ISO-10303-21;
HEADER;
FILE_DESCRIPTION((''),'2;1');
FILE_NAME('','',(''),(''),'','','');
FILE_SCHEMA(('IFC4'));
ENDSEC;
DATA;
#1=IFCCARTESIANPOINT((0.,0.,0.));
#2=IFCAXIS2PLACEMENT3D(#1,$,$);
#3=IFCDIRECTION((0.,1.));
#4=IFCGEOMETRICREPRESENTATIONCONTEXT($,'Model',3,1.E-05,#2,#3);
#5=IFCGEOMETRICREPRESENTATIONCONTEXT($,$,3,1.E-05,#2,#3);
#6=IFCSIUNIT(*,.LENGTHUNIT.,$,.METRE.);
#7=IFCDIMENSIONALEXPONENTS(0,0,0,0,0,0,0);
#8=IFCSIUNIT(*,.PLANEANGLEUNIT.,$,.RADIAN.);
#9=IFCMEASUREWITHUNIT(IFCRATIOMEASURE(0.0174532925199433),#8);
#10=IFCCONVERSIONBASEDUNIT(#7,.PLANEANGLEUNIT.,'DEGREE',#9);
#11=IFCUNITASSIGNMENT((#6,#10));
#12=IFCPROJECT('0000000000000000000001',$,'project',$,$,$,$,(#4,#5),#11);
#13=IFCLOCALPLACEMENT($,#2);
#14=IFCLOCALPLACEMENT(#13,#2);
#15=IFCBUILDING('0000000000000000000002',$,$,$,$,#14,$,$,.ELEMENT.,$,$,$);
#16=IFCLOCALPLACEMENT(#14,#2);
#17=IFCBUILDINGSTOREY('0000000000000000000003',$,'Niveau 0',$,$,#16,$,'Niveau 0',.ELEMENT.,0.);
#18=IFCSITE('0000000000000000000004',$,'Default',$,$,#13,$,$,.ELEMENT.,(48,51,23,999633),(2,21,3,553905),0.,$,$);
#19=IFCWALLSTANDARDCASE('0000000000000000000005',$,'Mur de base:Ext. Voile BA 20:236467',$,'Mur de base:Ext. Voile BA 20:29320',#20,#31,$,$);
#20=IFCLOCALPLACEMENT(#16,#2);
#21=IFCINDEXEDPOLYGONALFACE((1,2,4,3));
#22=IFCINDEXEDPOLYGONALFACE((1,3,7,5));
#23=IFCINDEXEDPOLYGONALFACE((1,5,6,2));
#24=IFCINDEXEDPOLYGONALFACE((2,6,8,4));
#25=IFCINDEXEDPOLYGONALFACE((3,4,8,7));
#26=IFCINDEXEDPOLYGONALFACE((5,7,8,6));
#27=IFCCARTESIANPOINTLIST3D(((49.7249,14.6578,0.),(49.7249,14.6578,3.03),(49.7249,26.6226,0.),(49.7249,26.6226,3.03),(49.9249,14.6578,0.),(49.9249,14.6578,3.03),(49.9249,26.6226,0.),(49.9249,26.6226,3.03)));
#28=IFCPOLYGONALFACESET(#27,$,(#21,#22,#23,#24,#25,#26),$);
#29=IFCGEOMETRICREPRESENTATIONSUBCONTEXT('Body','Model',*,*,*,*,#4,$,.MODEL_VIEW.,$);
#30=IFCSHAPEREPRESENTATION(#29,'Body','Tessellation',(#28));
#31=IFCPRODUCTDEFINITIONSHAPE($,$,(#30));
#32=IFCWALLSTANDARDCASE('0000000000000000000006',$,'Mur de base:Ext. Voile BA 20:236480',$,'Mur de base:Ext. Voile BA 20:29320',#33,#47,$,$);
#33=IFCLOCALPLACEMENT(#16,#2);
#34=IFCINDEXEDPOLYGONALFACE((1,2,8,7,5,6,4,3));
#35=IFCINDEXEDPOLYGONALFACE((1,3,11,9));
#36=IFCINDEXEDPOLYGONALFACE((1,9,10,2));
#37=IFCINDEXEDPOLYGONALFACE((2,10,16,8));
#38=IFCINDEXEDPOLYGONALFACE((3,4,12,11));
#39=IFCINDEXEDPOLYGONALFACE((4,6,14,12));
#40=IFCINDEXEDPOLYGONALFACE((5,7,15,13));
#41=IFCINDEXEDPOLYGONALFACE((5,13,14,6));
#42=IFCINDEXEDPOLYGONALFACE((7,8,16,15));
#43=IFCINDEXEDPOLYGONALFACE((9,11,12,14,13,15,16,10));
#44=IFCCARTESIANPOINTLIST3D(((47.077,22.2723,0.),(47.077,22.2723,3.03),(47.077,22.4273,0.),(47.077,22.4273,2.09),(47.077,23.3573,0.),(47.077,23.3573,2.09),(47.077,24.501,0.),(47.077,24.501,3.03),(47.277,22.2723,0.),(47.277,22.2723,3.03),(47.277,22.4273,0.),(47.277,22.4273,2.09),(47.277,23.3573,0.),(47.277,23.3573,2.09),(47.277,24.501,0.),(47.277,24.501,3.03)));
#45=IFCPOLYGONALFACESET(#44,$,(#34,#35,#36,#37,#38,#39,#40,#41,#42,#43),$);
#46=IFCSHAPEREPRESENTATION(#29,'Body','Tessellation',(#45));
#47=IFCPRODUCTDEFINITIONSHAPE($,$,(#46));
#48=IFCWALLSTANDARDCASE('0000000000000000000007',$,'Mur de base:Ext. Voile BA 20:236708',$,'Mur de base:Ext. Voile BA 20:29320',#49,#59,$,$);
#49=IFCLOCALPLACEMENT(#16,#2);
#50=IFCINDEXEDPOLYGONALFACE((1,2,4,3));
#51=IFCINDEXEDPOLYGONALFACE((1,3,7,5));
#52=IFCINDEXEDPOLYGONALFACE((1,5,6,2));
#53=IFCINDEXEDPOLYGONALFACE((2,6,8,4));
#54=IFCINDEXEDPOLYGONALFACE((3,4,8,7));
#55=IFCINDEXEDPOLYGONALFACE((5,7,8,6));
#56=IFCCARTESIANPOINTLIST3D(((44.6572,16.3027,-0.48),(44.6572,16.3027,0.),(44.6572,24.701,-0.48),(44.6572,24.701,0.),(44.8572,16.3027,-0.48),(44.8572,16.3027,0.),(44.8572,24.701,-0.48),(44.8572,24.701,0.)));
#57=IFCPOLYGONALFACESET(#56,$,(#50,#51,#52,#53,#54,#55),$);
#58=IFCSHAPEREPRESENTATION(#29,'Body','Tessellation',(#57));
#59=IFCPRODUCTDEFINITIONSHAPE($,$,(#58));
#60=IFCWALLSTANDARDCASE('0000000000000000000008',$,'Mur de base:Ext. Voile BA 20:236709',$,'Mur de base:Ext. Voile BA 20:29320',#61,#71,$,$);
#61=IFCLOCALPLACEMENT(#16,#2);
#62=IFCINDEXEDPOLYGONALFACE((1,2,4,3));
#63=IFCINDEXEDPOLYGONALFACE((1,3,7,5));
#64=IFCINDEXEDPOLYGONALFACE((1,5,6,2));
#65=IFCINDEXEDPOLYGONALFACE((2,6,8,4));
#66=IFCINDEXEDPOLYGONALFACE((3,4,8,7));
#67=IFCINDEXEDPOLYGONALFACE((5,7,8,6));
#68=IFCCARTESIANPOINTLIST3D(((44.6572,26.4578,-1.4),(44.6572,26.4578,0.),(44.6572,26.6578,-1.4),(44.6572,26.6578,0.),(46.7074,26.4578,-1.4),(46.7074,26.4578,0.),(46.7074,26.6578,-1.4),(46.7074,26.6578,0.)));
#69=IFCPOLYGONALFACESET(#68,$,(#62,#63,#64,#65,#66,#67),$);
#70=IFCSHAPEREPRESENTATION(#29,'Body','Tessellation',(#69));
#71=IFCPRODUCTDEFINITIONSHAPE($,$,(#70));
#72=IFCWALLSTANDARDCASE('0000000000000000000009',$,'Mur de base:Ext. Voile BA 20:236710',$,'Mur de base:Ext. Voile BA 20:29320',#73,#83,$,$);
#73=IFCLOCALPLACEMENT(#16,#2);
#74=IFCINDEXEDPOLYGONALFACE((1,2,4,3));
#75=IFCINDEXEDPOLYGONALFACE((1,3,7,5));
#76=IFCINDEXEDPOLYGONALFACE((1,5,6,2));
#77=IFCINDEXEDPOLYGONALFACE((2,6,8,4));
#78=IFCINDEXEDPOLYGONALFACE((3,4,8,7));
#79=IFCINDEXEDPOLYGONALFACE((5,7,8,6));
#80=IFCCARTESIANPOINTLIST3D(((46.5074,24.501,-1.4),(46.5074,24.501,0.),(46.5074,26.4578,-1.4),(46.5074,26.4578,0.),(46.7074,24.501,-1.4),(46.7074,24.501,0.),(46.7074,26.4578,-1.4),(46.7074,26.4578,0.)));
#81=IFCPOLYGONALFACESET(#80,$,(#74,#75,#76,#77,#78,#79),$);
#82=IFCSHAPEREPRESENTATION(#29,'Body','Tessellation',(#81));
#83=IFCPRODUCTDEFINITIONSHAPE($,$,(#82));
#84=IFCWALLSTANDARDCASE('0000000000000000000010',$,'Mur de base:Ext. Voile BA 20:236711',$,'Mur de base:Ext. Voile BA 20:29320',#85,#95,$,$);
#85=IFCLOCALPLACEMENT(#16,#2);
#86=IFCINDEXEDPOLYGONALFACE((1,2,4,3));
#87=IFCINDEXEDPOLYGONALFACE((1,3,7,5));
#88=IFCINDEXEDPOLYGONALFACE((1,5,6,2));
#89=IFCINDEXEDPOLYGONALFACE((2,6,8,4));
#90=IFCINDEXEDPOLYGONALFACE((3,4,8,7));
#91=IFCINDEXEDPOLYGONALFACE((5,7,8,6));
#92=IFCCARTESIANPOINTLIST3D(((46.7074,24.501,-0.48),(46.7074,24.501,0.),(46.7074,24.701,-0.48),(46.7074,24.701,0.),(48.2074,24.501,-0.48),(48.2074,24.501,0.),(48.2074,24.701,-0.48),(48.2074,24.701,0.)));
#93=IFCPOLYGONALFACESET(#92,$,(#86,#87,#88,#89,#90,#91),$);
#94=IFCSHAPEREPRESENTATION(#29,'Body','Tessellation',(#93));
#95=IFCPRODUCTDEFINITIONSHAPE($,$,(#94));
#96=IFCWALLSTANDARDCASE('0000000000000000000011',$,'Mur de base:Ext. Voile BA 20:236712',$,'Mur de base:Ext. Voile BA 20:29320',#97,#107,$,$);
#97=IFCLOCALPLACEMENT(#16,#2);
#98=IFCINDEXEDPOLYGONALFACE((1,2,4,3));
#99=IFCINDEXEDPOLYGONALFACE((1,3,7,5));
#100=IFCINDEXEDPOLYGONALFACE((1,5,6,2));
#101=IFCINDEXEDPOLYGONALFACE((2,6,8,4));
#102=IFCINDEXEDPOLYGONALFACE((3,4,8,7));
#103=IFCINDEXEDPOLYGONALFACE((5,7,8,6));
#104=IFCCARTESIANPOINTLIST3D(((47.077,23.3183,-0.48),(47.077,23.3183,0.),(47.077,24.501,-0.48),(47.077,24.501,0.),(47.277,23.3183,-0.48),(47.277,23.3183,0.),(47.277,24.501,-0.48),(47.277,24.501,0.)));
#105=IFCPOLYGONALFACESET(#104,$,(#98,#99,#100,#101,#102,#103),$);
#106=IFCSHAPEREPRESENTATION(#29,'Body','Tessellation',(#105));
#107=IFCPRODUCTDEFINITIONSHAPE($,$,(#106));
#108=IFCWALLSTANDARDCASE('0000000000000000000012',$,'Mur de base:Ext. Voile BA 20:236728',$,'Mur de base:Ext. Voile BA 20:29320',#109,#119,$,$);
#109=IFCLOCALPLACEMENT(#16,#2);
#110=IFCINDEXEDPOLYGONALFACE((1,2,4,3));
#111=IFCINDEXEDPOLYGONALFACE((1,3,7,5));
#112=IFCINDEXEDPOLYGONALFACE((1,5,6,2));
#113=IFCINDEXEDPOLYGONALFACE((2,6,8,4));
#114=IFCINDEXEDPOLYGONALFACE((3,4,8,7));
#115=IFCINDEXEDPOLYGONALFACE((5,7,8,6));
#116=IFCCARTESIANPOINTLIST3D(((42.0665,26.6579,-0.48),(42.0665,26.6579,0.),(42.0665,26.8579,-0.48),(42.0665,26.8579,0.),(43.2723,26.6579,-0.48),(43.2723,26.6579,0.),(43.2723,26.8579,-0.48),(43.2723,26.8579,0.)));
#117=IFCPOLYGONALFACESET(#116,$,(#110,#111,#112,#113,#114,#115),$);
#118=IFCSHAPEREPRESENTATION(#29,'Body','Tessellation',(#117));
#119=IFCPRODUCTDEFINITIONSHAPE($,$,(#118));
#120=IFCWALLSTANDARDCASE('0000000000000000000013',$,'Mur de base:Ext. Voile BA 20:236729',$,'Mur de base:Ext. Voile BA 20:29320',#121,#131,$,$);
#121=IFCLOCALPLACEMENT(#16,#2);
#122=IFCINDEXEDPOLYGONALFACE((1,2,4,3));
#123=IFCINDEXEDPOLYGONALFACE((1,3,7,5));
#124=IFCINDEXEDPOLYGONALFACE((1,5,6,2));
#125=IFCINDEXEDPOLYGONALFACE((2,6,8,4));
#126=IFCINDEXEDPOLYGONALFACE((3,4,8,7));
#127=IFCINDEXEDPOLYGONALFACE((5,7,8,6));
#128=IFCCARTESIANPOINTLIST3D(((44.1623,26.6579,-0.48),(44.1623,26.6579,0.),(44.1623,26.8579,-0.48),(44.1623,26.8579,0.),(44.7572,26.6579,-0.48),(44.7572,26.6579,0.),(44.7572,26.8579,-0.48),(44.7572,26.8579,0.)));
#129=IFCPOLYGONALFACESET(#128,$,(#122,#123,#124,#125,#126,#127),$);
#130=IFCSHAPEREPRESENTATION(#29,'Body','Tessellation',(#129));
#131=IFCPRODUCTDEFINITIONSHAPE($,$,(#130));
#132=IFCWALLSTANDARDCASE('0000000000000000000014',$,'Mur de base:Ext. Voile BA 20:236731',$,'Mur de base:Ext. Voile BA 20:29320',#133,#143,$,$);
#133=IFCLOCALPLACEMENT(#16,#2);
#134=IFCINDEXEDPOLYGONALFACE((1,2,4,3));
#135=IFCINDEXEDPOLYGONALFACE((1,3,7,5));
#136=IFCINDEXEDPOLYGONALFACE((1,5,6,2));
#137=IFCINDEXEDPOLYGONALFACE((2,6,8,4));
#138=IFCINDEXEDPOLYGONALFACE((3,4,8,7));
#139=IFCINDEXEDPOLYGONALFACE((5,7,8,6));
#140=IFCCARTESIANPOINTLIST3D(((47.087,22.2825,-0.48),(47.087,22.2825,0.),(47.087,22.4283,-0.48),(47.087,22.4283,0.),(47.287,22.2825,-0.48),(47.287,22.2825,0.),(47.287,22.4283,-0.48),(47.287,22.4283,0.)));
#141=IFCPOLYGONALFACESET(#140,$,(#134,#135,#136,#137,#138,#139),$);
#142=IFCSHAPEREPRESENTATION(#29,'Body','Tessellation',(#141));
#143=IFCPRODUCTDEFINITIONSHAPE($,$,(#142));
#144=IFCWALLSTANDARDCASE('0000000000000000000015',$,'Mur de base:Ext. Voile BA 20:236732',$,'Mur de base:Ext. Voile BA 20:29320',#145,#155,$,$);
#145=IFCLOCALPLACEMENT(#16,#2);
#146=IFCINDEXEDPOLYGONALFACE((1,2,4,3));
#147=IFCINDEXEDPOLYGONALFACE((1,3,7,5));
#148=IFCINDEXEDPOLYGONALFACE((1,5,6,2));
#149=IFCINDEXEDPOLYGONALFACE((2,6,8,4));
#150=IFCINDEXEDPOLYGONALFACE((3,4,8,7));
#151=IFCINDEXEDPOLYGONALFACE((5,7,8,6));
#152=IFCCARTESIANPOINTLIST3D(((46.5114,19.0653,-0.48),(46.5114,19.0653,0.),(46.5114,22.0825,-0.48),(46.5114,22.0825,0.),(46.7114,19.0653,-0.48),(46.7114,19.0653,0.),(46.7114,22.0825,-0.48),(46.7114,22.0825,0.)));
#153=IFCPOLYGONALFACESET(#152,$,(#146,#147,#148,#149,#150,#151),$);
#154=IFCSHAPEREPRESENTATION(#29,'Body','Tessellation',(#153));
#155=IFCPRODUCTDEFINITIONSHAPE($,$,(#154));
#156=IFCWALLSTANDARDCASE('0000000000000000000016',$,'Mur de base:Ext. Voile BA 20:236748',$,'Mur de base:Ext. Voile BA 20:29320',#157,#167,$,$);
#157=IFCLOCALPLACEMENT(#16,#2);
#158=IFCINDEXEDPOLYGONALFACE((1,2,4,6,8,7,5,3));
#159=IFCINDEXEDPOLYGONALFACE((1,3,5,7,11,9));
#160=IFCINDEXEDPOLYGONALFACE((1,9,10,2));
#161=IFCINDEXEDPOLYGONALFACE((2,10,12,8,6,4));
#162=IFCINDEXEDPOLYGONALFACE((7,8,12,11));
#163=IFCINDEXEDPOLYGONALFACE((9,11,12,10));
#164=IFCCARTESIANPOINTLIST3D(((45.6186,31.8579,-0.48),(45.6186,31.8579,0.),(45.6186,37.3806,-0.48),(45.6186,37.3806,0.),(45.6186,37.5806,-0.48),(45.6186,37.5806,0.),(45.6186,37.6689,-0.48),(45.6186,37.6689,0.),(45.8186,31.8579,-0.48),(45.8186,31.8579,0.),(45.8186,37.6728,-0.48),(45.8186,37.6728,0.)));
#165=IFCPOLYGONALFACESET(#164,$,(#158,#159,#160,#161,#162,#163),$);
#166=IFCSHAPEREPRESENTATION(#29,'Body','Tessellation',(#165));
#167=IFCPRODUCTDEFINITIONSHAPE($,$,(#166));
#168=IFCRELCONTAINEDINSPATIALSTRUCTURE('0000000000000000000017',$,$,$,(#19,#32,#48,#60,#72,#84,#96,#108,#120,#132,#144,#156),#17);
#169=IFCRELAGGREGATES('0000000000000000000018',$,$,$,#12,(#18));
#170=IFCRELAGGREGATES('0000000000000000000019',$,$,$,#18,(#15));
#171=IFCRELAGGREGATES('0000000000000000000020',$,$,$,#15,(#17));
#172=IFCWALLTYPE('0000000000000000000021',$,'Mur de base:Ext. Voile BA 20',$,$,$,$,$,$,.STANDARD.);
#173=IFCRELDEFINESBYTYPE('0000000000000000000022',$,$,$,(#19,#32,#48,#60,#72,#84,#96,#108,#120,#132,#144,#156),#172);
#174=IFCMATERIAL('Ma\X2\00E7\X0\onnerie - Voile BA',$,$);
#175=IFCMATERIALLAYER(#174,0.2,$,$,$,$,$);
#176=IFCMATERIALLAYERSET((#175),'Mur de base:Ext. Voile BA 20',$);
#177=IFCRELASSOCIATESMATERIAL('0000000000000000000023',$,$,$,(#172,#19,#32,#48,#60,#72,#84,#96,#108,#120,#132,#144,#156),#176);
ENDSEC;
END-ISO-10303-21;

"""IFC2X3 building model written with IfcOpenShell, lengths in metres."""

from ifc_helpers import new_model, entity, si_unit, converted_unit, direction, frame, frame_2d, origin, origin_2d_with_axis, place, context, subcontext, project, spatial, polyline, rectangle, outline, extrude, material, layer, layer_set, layer_usage, type_object, element, save


model = new_model("IFC2X3")

# Units and contexts
model_context = context("Model", 3, precision=1e-05, world=origin(), true_north=direction((0.0, 1.0)))
context_of_model = context(None, 3, precision=1e-05, world=origin(), true_north=direction((0.0, 1.0)))
body_context = subcontext(model_context, "Body", "Model", "MODEL_VIEW")
ifc_project = project(units=[si_unit("LENGTHUNIT", "METRE"), converted_unit("PLANEANGLEUNIT", "DEGREE", entity("IfcRatioMeasure", 0.0174532925199433), si_unit("PLANEANGLEUNIT", "RADIAN"), dimensions=[0, 0, 0, 0, 0, 0, 0])], contexts=[model_context, context_of_model])

# Site, building, storey
site_placement = place(None, origin())
site = spatial("IfcSite", under=ifc_project, at=site_placement, Name="Default", CompositionType="ELEMENT", RefLatitude=(48, 51, 23, 999633), RefLongitude=(2, 21, 3, 553905), RefElevation=0.0)
building_placement = place(site_placement, origin())
building = spatial("IfcBuilding", under=site, at=building_placement, CompositionType="ELEMENT")
storey_placement = place(building_placement, origin())
storey = spatial("IfcBuildingStorey", under=building, at=storey_placement, Name="Niveau 0", LongName="Niveau 0", CompositionType="ELEMENT", Elevation=0.0)

# Shared definitions
ifc_material = material(Name="Maçonnerie - Voile BA")
ifc_layer_1 = layer(ifc_material, 0.2)
ifc_layer_set_1 = layer_set([ifc_layer_1], Name="Mur de base:Ext. Voile BA 20")
wall_type_1 = type_object("IfcWallType", Name="Mur de base:Ext. Voile BA 20", PredefinedType="STANDARD", material=ifc_layer_set_1)

# Wall
ifc_layer_usage_1 = layer_usage(ifc_layer_set_1, "AXIS2", "NEGATIVE", 0.1)
wall_1_placement = place(storey_placement, frame((49.8249, 26.6226, 0.0), z_axis=(0.0, 0.0, 1.0), x_axis=(0.0, -1.0, 0.0)))
element("IfcWallStandardCase", 1, at=wall_1_placement, inside=storey, type_object=wall_type_1, material=ifc_layer_usage_1, Name="Mur de base:Ext. Voile BA 20:236467", ObjectType="Mur de base:Ext. Voile BA 20:29320", context=body_context, shape_type="SweptSolid", body=[
    extrude(rectangle(XDim=11.9648, YDim=0.2, at=frame_2d((5.9824, 0.0), x_axis=(-1.0, 0.0))), origin(), (0.0, 0.0, 1.0), 3.03),
])

# Wall, opening
ifc_layer_usage_2 = layer_usage(ifc_layer_set_1, "AXIS2", "NEGATIVE", 0.1)
wall_2_placement = place(storey_placement, frame((47.177, 24.501, 0.0), z_axis=(0.0, 0.0, 1.0), x_axis=(0.0, -1.0, 0.0)))
wall_2 = element("IfcWallStandardCase", 2, at=wall_2_placement, inside=storey, type_object=wall_type_1, material=ifc_layer_usage_2, Name="Mur de base:Ext. Voile BA 20:236480", ObjectType="Mur de base:Ext. Voile BA 20:29320", context=body_context, shape_type="SweptSolid", body=[
    extrude(rectangle(XDim=2.2287, YDim=0.2, at=frame_2d((1.1144, 0.0), x_axis=(-1.0, 0.0))), origin(), (0.0, 0.0, 1.0), 3.03),
])
opening_1_placement = place(wall_2_placement, origin())
element("IfcOpeningElement", 3, at=opening_1_placement, cuts=wall_2, ObjectType="Opening", context=body_context, shape_type="SweptSolid", body=[
    extrude(rectangle(XDim=2.09, YDim=0.93, at=origin_2d_with_axis()), frame((1.6087, -0.1, 1.045), z_axis=(0.0, 1.0, 0.0), x_axis=(0.0, 0.0, -1.0)), (0.0, 0.0, 1.0), 0.2),
])

# Walls
ifc_layer_usage_3 = layer_usage(ifc_layer_set_1, "AXIS2", "NEGATIVE", 0.1)
wall_3_placement = place(storey_placement, frame((44.7572, 24.701, -0.48), z_axis=(0.0, 0.0, 1.0), x_axis=(0.0, -1.0, 0.0)))
element("IfcWallStandardCase", 4, at=wall_3_placement, inside=storey, type_object=wall_type_1, material=ifc_layer_usage_3, Name="Mur de base:Ext. Voile BA 20:236708", ObjectType="Mur de base:Ext. Voile BA 20:29320", context=body_context, shape_type="SweptSolid", body=[
    extrude(rectangle(XDim=8.3983, YDim=0.2, at=frame_2d((4.1992, 0.0), x_axis=(-1.0, 0.0))), origin(), (0.0, 0.0, 1.0), 0.48),
])
ifc_layer_usage_4 = layer_usage(ifc_layer_set_1, "AXIS2", "NEGATIVE", 0.1)
wall_4_placement = place(storey_placement, frame((44.6572, 26.5578, -1.4)))
element("IfcWallStandardCase", 5, at=wall_4_placement, inside=storey, type_object=wall_type_1, material=ifc_layer_usage_4, Name="Mur de base:Ext. Voile BA 20:236709", ObjectType="Mur de base:Ext. Voile BA 20:29320", context=body_context, shape_type="SweptSolid", body=[
    extrude(rectangle(XDim=2.0501, YDim=0.2, at=frame_2d((1.0251, 0.0), x_axis=(-1.0, 0.0))), origin(), (0.0, 0.0, 1.0), 1.4),
])
ifc_layer_usage_5 = layer_usage(ifc_layer_set_1, "AXIS2", "NEGATIVE", 0.1)
wall_5_placement = place(storey_placement, frame((46.6074, 26.4578, -1.4), z_axis=(0.0, 0.0, 1.0), x_axis=(0.0, -1.0, 0.0)))
element("IfcWallStandardCase", 6, at=wall_5_placement, inside=storey, type_object=wall_type_1, material=ifc_layer_usage_5, Name="Mur de base:Ext. Voile BA 20:236710", ObjectType="Mur de base:Ext. Voile BA 20:29320", context=body_context, shape_type="SweptSolid", body=[
    extrude(rectangle(XDim=1.9568, YDim=0.2, at=frame_2d((0.9784, 0.0), x_axis=(-1.0, 0.0))), origin(), (0.0, 0.0, 1.0), 1.4),
])
ifc_layer_usage_6 = layer_usage(ifc_layer_set_1, "AXIS2", "NEGATIVE", 0.1)
wall_6_placement = place(storey_placement, frame((46.7074, 24.601, -0.48)))
element("IfcWallStandardCase", 7, at=wall_6_placement, inside=storey, type_object=wall_type_1, material=ifc_layer_usage_6, Name="Mur de base:Ext. Voile BA 20:236711", ObjectType="Mur de base:Ext. Voile BA 20:29320", context=body_context, shape_type="SweptSolid", body=[
    extrude(rectangle(XDim=1.5, YDim=0.2, at=frame_2d((0.75, 0.0), x_axis=(-1.0, 0.0))), origin(), (0.0, 0.0, 1.0), 0.48),
])
ifc_layer_usage_7 = layer_usage(ifc_layer_set_1, "AXIS2", "NEGATIVE", 0.1)
wall_7_placement = place(storey_placement, frame((47.177, 23.3183, -0.48), z_axis=(0.0, 0.0, 1.0), x_axis=(0.0, 1.0, 0.0)))
element("IfcWallStandardCase", 8, at=wall_7_placement, inside=storey, type_object=wall_type_1, material=ifc_layer_usage_7, Name="Mur de base:Ext. Voile BA 20:236712", ObjectType="Mur de base:Ext. Voile BA 20:29320", context=body_context, shape_type="SweptSolid", body=[
    extrude(rectangle(XDim=1.1827, YDim=0.2, at=frame_2d((0.5914, 0.0), x_axis=(-1.0, 0.0))), origin(), (0.0, 0.0, 1.0), 0.48),
])
ifc_layer_usage_8 = layer_usage(ifc_layer_set_1, "AXIS2", "NEGATIVE", 0.1)
wall_8_placement = place(storey_placement, frame((42.0665, 26.7579, -0.48)))
element("IfcWallStandardCase", 9, at=wall_8_placement, inside=storey, type_object=wall_type_1, material=ifc_layer_usage_8, Name="Mur de base:Ext. Voile BA 20:236728", ObjectType="Mur de base:Ext. Voile BA 20:29320", context=body_context, shape_type="SweptSolid", body=[
    extrude(rectangle(XDim=1.2058, YDim=0.2, at=frame_2d((0.6029, 0.0), x_axis=(-1.0, 0.0))), origin(), (0.0, 0.0, 1.0), 0.48),
])
ifc_layer_usage_9 = layer_usage(ifc_layer_set_1, "AXIS2", "NEGATIVE", 0.1)
wall_9_placement = place(storey_placement, frame((44.1623, 26.7579, -0.48)))
element("IfcWallStandardCase", 10, at=wall_9_placement, inside=storey, type_object=wall_type_1, material=ifc_layer_usage_9, Name="Mur de base:Ext. Voile BA 20:236729", ObjectType="Mur de base:Ext. Voile BA 20:29320", context=body_context, shape_type="SweptSolid", body=[
    extrude(rectangle(XDim=0.595, YDim=0.2, at=frame_2d((0.2975, 0.0), x_axis=(-1.0, 0.0))), origin(), (0.0, 0.0, 1.0), 0.48),
])
ifc_layer_usage_10 = layer_usage(ifc_layer_set_1, "AXIS2", "NEGATIVE", 0.1)
wall_10_placement = place(storey_placement, frame((47.187, 22.2825, -0.48), z_axis=(0.0, 0.0, 1.0), x_axis=(0.0, 1.0, 0.0)))
element("IfcWallStandardCase", 11, at=wall_10_placement, inside=storey, type_object=wall_type_1, material=ifc_layer_usage_10, Name="Mur de base:Ext. Voile BA 20:236731", ObjectType="Mur de base:Ext. Voile BA 20:29320", context=body_context, shape_type="SweptSolid", body=[
    extrude(rectangle(XDim=0.1458, YDim=0.2, at=frame_2d((0.0729, 0.0), x_axis=(-1.0, 0.0))), origin(), (0.0, 0.0, 1.0), 0.48),
])
ifc_layer_usage_11 = layer_usage(ifc_layer_set_1, "AXIS2", "NEGATIVE", 0.1)
wall_11_placement = place(storey_placement, frame((46.6114, 22.0825, -0.48), z_axis=(0.0, 0.0, 1.0), x_axis=(0.0, -1.0, 0.0)))
element("IfcWallStandardCase", 12, at=wall_11_placement, inside=storey, type_object=wall_type_1, material=ifc_layer_usage_11, Name="Mur de base:Ext. Voile BA 20:236732", ObjectType="Mur de base:Ext. Voile BA 20:29320", context=body_context, shape_type="SweptSolid", body=[
    extrude(rectangle(XDim=3.0172, YDim=0.2, at=frame_2d((1.5086, 0.0), x_axis=(-1.0, 0.0))), origin(), (0.0, 0.0, 1.0), 0.48),
])
ifc_layer_usage_12 = layer_usage(ifc_layer_set_1, "AXIS2", "NEGATIVE", 0.1)
wall_12_placement = place(storey_placement, frame((45.7186, 37.6728, -0.48), z_axis=(0.0, 0.0, 1.0), x_axis=(0.0, -1.0, 0.0)))
element("IfcWallStandardCase", 13, at=wall_12_placement, inside=storey, type_object=wall_type_1, material=ifc_layer_usage_12, Name="Mur de base:Ext. Voile BA 20:236748", ObjectType="Mur de base:Ext. Voile BA 20:29320", context=body_context, shape_type="SweptSolid", body=[
    extrude(outline(polyline([(5.8149, -0.1), (5.8149, 0.1), (0.0, 0.1), (0.004, -0.1), (0.0922, -0.1), (0.2922, -0.1), (5.8149, -0.1)])), origin(), (0.0, 0.0, 1.0), 0.48),
])

save(model, "model.ifc")
